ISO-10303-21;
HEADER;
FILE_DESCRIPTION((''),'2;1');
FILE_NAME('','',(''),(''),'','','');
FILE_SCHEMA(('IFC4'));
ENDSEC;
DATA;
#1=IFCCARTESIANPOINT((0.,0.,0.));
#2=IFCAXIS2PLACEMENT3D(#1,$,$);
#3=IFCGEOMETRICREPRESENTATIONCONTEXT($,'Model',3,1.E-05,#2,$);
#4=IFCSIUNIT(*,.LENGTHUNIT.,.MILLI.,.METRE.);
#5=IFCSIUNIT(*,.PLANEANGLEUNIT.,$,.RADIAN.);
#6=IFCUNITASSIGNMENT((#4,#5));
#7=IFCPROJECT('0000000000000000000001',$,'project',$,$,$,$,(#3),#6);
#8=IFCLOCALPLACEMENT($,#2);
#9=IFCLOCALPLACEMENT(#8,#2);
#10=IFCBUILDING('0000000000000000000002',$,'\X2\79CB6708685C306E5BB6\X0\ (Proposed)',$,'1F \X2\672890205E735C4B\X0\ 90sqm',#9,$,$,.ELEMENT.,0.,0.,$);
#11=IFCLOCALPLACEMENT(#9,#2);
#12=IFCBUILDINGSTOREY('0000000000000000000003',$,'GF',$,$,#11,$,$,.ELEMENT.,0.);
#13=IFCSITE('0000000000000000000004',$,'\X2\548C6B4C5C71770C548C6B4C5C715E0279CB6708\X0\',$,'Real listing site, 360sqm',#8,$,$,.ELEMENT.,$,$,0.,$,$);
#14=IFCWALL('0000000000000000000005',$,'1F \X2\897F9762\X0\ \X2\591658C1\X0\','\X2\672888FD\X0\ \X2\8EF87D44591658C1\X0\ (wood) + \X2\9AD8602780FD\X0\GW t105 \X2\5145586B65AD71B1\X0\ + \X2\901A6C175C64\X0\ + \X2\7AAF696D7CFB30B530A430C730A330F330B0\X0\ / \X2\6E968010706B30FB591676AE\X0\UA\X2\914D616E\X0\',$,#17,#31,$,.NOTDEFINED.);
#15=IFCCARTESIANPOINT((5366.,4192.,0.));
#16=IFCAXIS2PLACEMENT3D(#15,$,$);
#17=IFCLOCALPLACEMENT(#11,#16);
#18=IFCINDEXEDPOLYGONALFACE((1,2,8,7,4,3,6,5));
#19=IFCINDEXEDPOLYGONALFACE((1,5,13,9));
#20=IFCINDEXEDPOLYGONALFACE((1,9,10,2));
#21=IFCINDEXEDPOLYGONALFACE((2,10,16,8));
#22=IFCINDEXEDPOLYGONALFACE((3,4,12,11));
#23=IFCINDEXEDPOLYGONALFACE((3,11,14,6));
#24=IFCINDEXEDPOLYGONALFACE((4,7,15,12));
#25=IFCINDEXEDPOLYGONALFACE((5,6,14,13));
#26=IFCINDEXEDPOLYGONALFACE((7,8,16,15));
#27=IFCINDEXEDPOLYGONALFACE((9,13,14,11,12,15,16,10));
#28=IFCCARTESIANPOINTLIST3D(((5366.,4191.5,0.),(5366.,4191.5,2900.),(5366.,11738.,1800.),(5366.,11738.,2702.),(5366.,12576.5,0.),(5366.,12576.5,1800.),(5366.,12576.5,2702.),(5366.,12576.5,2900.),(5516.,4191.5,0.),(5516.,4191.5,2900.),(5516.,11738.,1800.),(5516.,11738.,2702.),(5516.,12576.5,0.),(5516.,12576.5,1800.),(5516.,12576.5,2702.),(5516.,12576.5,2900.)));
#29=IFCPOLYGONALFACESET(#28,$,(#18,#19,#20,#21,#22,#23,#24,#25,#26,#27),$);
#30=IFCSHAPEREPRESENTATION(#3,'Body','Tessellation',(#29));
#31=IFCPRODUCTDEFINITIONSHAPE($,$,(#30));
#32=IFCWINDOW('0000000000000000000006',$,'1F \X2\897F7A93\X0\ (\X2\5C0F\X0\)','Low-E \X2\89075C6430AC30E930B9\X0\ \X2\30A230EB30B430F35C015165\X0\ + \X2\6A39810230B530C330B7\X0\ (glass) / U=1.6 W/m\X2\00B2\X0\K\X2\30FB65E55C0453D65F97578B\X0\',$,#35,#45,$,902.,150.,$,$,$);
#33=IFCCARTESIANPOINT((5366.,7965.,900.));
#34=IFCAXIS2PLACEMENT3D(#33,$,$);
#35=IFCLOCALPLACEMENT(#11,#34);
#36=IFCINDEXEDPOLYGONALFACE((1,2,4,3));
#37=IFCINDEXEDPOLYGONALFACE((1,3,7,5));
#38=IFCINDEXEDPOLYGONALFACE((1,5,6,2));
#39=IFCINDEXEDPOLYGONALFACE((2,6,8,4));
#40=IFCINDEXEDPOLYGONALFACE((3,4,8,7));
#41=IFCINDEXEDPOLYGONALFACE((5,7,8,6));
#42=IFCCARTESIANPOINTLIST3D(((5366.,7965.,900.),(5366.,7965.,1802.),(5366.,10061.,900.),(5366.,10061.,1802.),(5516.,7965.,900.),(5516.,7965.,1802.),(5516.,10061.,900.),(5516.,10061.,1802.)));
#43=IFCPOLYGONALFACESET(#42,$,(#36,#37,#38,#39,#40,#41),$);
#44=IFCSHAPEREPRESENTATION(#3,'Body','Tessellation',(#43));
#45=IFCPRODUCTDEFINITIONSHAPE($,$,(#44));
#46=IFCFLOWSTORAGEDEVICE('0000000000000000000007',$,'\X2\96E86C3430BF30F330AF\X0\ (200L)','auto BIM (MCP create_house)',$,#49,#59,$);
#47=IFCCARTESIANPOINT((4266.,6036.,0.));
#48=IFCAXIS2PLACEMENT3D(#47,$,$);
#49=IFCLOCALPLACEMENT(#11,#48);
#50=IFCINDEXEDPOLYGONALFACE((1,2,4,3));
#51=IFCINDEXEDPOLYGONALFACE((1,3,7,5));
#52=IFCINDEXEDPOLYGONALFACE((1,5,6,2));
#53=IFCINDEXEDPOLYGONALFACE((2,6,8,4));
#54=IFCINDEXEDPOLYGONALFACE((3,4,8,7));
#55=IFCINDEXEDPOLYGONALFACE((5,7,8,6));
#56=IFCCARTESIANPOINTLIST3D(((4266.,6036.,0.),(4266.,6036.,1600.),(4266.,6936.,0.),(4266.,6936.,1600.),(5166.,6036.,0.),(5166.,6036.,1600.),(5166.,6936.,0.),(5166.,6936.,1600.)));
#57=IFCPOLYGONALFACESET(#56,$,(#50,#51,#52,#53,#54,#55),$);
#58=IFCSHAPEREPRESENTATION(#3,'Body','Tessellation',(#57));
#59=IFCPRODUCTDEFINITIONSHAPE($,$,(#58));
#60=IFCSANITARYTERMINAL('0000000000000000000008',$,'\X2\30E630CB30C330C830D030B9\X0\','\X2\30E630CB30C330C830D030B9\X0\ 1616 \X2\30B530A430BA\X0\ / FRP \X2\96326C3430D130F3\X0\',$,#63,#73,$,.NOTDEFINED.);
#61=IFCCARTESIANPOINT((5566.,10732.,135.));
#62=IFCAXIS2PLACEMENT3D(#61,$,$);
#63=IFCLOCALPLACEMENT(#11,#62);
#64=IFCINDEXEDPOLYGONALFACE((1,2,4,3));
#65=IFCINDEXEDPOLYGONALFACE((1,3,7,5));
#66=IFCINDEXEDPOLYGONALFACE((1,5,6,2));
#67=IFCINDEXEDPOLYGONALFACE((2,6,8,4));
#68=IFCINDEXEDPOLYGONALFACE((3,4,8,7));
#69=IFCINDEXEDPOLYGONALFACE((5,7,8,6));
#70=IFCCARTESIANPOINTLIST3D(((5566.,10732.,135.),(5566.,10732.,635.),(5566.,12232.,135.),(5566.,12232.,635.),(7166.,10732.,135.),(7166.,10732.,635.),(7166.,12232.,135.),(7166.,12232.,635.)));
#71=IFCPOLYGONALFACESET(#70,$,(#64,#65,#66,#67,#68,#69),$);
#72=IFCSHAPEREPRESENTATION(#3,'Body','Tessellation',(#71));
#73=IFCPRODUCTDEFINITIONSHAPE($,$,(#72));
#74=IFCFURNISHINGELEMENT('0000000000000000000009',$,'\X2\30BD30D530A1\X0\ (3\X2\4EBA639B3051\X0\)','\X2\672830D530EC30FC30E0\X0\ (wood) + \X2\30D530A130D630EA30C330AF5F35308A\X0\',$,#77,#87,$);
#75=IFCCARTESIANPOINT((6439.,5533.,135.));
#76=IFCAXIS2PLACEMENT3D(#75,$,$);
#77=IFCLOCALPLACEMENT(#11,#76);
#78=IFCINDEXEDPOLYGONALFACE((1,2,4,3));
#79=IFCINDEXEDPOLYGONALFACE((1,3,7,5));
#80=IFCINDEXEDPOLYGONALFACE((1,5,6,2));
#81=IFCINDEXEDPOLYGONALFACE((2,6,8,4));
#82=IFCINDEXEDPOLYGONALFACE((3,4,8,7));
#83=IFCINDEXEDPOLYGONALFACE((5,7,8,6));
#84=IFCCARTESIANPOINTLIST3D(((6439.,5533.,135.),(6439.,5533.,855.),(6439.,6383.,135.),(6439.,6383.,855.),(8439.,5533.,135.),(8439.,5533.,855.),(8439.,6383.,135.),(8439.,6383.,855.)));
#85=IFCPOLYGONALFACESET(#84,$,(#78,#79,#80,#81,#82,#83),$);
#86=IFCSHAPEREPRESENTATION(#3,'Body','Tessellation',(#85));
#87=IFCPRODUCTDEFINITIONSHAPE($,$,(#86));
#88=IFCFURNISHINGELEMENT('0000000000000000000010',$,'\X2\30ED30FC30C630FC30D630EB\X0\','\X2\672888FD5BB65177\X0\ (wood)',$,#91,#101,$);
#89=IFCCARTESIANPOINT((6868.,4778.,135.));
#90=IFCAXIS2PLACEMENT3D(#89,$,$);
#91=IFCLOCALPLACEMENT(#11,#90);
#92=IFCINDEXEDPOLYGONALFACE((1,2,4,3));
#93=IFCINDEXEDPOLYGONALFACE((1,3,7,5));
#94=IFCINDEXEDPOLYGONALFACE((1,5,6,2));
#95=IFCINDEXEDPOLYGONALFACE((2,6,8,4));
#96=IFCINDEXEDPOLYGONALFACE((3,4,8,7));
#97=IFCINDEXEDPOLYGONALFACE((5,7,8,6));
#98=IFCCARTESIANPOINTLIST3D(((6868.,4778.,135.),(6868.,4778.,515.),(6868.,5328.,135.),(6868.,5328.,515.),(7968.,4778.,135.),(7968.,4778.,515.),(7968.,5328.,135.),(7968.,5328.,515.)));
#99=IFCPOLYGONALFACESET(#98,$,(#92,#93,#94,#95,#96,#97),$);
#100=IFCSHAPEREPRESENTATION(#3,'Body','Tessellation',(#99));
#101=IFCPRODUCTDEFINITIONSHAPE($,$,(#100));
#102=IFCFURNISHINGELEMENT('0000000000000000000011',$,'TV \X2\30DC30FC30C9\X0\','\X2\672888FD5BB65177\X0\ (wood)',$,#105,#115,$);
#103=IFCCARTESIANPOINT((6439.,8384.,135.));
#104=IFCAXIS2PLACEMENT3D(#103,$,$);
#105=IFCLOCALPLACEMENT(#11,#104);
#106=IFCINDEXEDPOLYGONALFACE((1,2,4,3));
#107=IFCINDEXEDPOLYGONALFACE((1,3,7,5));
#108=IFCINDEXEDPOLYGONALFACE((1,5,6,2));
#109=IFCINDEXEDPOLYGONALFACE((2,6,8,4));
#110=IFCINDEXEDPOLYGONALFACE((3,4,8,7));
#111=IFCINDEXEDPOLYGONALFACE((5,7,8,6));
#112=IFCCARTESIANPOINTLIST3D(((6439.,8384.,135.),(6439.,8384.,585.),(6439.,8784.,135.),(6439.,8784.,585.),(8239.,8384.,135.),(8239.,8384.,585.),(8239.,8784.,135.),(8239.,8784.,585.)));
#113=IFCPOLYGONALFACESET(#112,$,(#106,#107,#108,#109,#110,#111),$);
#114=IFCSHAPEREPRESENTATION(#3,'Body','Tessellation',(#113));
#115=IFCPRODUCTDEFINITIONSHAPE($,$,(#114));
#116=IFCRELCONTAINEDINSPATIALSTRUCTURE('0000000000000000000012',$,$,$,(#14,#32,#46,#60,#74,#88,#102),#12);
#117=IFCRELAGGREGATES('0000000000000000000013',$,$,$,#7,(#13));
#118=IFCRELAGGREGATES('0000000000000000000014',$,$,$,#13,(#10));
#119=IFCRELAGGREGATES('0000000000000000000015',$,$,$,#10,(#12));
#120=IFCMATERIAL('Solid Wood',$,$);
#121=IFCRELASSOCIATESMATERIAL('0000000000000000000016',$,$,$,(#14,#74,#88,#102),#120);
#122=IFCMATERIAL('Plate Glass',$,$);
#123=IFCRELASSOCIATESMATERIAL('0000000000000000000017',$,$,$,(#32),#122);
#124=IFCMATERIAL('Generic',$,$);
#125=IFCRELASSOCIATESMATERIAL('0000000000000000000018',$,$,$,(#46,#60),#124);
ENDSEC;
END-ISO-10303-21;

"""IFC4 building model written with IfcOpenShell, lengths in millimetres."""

from ifc_helpers import new_model, si_unit, frame, frame_2d, origin, place, context, project, spatial, rectangle, extrude, material, element, fill, save


model = new_model("IFC4")

# Units and contexts
model_context = context("Model", 3, precision=1e-05, world=origin())
ifc_project = project(units=[si_unit("LENGTHUNIT", "METRE", prefix="MILLI"), si_unit("PLANEANGLEUNIT", "RADIAN")], contexts=[model_context])

# Site, building, storey
site_placement = place(None, origin())
site = spatial("IfcSite", under=ifc_project, at=site_placement, Name="和歌山県和歌山市秋月", ObjectType="Real listing site, 360sqm", CompositionType="ELEMENT", RefElevation=0.0)
building_placement = place(site_placement, origin())
building = spatial("IfcBuilding", under=site, at=building_placement, Name="秋月桜の家 (Proposed)", ObjectType="1F 木造平屋 90sqm", CompositionType="ELEMENT", ElevationOfRefHeight=0.0, ElevationOfTerrain=0.0)
storey_placement = place(building_placement, origin())
storey = spatial("IfcBuildingStorey", under=building, at=storey_placement, Name="GF", CompositionType="ELEMENT", Elevation=0.0)

# Shared definitions
ifc_material_1 = material(Name="Solid Wood")

# Shared definitions
ifc_material_2 = material(Name="Plate Glass")

# Wall, opening, window
wall_1_placement = place(storey_placement, frame((5366.0, 4192.0, 0.0)))
wall_1 = element("IfcWall", 1, at=wall_1_placement, inside=storey, material=ifc_material_1, Name="1F 西面 外壁", Description="木製 軸組外壁 (wood) + 高性能GW t105 充填断熱 + 通気層 + 窯業系サイディング / 準耐火・外皮UA配慮", PredefinedType="NOTDEFINED", context=model_context, shape_type="SweptSolid", body=[
    extrude(rectangle(XDim=150.0, YDim=8385.0, at=frame_2d((75.0, 4192.0))), frame((5366.0, 4192.0, 0.0)), (0.0, 0.0, 1.0), 2900.0),
])
opening_1_placement = place(storey_placement, frame((5366.0, 7965.0, 900.0)))
opening_1 = element("IfcOpeningElement", 2, at=opening_1_placement, cuts=wall_1, PredefinedType="NOTDEFINED", context=model_context, shape_type="SweptSolid", body=[
    extrude(rectangle(XDim=150.0, YDim=2096.0, at=frame_2d((75.0, 1048.0))), frame((5366.0, 7965.0, 900.0)), (0.0, 0.0, 1.0), 902.0),
])
window_1_placement = place(storey_placement, frame((5366.0, 7965.0, 900.0)))
window_1 = element("IfcWindow", 3, at=window_1_placement, inside=storey, material=ifc_material_2, Name="1F 西窓 (小)", Description="Low-E 複層ガラス アルゴン封入 + 樹脂サッシ (glass) / U=1.6 W/m²K・日射取得型", OverallHeight=902.0, OverallWidth=150.0, context=model_context, shape_type="SweptSolid", body=[
    extrude(rectangle(XDim=150.0, YDim=2096.0, at=frame_2d((75.0, 1048.0))), frame((5366.0, 7965.0, 900.0)), (0.0, 0.0, 1.0), 902.0),
])
fill(opening_1, window_1)

# Shared definitions
ifc_material_3 = material(Name="Generic")

# Flow storage device
flow_storage_device_placement = place(storey_placement, frame((4266.0, 6036.0, 0.0)))
element("IfcFlowStorageDevice", 4, at=flow_storage_device_placement, inside=storey, material=ifc_material_3, Name="雨水タンク (200L)", Description="auto BIM (MCP create_house)", context=model_context, shape_type="SweptSolid", body=[
    extrude(rectangle(XDim=900.0, YDim=900.0, at=frame_2d((450.0, 450.0))), frame((4266.0, 6036.0, 0.0)), (0.0, 0.0, 1.0), 1600.0),
])

# Sanitary terminal
sanitary_terminal_placement = place(storey_placement, frame((5566.0, 10732.0, 135.0)))
element("IfcSanitaryTerminal", 5, at=sanitary_terminal_placement, inside=storey, material=ifc_material_3, Name="ユニットバス", Description="ユニットバス 1616 サイズ / FRP 防水パン", PredefinedType="NOTDEFINED", context=model_context, shape_type="SweptSolid", body=[
    extrude(rectangle(XDim=1600.0, YDim=1500.0, at=frame_2d((800.0, 750.0))), frame((5566.0, 10732.0, 135.0)), (0.0, 0.0, 1.0), 500.0),
])

# Furnishing elements
furnishing_1_placement = place(storey_placement, frame((6439.0, 5533.0, 135.0)))
element("IfcFurnishingElement", 6, at=furnishing_1_placement, inside=storey, material=ifc_material_1, Name="ソファ (3人掛け)", Description="木フレーム (wood) + ファブリック張り", context=model_context, shape_type="SweptSolid", body=[
    extrude(rectangle(XDim=2000.0, YDim=850.0, at=frame_2d((1000.0, 425.0))), frame((6439.0, 5533.0, 135.0)), (0.0, 0.0, 1.0), 720.0),
])
furnishing_2_placement = place(storey_placement, frame((6868.0, 4778.0, 135.0)))
element("IfcFurnishingElement", 7, at=furnishing_2_placement, inside=storey, material=ifc_material_1, Name="ローテーブル", Description="木製家具 (wood)", context=model_context, shape_type="SweptSolid", body=[
    extrude(rectangle(XDim=1100.0, YDim=550.0, at=frame_2d((550.0, 275.0))), frame((6868.0, 4778.0, 135.0)), (0.0, 0.0, 1.0), 380.0),
])
furnishing_3_placement = place(storey_placement, frame((6439.0, 8384.0, 135.0)))
element("IfcFurnishingElement", 8, at=furnishing_3_placement, inside=storey, material=ifc_material_1, Name="TV ボード", Description="木製家具 (wood)", context=model_context, shape_type="SweptSolid", body=[
    extrude(rectangle(XDim=1800.0, YDim=400.0, at=frame_2d((900.0, 200.0))), frame((6439.0, 8384.0, 135.0)), (0.0, 0.0, 1.0), 450.0),
])

save(model, "model.ifc")
